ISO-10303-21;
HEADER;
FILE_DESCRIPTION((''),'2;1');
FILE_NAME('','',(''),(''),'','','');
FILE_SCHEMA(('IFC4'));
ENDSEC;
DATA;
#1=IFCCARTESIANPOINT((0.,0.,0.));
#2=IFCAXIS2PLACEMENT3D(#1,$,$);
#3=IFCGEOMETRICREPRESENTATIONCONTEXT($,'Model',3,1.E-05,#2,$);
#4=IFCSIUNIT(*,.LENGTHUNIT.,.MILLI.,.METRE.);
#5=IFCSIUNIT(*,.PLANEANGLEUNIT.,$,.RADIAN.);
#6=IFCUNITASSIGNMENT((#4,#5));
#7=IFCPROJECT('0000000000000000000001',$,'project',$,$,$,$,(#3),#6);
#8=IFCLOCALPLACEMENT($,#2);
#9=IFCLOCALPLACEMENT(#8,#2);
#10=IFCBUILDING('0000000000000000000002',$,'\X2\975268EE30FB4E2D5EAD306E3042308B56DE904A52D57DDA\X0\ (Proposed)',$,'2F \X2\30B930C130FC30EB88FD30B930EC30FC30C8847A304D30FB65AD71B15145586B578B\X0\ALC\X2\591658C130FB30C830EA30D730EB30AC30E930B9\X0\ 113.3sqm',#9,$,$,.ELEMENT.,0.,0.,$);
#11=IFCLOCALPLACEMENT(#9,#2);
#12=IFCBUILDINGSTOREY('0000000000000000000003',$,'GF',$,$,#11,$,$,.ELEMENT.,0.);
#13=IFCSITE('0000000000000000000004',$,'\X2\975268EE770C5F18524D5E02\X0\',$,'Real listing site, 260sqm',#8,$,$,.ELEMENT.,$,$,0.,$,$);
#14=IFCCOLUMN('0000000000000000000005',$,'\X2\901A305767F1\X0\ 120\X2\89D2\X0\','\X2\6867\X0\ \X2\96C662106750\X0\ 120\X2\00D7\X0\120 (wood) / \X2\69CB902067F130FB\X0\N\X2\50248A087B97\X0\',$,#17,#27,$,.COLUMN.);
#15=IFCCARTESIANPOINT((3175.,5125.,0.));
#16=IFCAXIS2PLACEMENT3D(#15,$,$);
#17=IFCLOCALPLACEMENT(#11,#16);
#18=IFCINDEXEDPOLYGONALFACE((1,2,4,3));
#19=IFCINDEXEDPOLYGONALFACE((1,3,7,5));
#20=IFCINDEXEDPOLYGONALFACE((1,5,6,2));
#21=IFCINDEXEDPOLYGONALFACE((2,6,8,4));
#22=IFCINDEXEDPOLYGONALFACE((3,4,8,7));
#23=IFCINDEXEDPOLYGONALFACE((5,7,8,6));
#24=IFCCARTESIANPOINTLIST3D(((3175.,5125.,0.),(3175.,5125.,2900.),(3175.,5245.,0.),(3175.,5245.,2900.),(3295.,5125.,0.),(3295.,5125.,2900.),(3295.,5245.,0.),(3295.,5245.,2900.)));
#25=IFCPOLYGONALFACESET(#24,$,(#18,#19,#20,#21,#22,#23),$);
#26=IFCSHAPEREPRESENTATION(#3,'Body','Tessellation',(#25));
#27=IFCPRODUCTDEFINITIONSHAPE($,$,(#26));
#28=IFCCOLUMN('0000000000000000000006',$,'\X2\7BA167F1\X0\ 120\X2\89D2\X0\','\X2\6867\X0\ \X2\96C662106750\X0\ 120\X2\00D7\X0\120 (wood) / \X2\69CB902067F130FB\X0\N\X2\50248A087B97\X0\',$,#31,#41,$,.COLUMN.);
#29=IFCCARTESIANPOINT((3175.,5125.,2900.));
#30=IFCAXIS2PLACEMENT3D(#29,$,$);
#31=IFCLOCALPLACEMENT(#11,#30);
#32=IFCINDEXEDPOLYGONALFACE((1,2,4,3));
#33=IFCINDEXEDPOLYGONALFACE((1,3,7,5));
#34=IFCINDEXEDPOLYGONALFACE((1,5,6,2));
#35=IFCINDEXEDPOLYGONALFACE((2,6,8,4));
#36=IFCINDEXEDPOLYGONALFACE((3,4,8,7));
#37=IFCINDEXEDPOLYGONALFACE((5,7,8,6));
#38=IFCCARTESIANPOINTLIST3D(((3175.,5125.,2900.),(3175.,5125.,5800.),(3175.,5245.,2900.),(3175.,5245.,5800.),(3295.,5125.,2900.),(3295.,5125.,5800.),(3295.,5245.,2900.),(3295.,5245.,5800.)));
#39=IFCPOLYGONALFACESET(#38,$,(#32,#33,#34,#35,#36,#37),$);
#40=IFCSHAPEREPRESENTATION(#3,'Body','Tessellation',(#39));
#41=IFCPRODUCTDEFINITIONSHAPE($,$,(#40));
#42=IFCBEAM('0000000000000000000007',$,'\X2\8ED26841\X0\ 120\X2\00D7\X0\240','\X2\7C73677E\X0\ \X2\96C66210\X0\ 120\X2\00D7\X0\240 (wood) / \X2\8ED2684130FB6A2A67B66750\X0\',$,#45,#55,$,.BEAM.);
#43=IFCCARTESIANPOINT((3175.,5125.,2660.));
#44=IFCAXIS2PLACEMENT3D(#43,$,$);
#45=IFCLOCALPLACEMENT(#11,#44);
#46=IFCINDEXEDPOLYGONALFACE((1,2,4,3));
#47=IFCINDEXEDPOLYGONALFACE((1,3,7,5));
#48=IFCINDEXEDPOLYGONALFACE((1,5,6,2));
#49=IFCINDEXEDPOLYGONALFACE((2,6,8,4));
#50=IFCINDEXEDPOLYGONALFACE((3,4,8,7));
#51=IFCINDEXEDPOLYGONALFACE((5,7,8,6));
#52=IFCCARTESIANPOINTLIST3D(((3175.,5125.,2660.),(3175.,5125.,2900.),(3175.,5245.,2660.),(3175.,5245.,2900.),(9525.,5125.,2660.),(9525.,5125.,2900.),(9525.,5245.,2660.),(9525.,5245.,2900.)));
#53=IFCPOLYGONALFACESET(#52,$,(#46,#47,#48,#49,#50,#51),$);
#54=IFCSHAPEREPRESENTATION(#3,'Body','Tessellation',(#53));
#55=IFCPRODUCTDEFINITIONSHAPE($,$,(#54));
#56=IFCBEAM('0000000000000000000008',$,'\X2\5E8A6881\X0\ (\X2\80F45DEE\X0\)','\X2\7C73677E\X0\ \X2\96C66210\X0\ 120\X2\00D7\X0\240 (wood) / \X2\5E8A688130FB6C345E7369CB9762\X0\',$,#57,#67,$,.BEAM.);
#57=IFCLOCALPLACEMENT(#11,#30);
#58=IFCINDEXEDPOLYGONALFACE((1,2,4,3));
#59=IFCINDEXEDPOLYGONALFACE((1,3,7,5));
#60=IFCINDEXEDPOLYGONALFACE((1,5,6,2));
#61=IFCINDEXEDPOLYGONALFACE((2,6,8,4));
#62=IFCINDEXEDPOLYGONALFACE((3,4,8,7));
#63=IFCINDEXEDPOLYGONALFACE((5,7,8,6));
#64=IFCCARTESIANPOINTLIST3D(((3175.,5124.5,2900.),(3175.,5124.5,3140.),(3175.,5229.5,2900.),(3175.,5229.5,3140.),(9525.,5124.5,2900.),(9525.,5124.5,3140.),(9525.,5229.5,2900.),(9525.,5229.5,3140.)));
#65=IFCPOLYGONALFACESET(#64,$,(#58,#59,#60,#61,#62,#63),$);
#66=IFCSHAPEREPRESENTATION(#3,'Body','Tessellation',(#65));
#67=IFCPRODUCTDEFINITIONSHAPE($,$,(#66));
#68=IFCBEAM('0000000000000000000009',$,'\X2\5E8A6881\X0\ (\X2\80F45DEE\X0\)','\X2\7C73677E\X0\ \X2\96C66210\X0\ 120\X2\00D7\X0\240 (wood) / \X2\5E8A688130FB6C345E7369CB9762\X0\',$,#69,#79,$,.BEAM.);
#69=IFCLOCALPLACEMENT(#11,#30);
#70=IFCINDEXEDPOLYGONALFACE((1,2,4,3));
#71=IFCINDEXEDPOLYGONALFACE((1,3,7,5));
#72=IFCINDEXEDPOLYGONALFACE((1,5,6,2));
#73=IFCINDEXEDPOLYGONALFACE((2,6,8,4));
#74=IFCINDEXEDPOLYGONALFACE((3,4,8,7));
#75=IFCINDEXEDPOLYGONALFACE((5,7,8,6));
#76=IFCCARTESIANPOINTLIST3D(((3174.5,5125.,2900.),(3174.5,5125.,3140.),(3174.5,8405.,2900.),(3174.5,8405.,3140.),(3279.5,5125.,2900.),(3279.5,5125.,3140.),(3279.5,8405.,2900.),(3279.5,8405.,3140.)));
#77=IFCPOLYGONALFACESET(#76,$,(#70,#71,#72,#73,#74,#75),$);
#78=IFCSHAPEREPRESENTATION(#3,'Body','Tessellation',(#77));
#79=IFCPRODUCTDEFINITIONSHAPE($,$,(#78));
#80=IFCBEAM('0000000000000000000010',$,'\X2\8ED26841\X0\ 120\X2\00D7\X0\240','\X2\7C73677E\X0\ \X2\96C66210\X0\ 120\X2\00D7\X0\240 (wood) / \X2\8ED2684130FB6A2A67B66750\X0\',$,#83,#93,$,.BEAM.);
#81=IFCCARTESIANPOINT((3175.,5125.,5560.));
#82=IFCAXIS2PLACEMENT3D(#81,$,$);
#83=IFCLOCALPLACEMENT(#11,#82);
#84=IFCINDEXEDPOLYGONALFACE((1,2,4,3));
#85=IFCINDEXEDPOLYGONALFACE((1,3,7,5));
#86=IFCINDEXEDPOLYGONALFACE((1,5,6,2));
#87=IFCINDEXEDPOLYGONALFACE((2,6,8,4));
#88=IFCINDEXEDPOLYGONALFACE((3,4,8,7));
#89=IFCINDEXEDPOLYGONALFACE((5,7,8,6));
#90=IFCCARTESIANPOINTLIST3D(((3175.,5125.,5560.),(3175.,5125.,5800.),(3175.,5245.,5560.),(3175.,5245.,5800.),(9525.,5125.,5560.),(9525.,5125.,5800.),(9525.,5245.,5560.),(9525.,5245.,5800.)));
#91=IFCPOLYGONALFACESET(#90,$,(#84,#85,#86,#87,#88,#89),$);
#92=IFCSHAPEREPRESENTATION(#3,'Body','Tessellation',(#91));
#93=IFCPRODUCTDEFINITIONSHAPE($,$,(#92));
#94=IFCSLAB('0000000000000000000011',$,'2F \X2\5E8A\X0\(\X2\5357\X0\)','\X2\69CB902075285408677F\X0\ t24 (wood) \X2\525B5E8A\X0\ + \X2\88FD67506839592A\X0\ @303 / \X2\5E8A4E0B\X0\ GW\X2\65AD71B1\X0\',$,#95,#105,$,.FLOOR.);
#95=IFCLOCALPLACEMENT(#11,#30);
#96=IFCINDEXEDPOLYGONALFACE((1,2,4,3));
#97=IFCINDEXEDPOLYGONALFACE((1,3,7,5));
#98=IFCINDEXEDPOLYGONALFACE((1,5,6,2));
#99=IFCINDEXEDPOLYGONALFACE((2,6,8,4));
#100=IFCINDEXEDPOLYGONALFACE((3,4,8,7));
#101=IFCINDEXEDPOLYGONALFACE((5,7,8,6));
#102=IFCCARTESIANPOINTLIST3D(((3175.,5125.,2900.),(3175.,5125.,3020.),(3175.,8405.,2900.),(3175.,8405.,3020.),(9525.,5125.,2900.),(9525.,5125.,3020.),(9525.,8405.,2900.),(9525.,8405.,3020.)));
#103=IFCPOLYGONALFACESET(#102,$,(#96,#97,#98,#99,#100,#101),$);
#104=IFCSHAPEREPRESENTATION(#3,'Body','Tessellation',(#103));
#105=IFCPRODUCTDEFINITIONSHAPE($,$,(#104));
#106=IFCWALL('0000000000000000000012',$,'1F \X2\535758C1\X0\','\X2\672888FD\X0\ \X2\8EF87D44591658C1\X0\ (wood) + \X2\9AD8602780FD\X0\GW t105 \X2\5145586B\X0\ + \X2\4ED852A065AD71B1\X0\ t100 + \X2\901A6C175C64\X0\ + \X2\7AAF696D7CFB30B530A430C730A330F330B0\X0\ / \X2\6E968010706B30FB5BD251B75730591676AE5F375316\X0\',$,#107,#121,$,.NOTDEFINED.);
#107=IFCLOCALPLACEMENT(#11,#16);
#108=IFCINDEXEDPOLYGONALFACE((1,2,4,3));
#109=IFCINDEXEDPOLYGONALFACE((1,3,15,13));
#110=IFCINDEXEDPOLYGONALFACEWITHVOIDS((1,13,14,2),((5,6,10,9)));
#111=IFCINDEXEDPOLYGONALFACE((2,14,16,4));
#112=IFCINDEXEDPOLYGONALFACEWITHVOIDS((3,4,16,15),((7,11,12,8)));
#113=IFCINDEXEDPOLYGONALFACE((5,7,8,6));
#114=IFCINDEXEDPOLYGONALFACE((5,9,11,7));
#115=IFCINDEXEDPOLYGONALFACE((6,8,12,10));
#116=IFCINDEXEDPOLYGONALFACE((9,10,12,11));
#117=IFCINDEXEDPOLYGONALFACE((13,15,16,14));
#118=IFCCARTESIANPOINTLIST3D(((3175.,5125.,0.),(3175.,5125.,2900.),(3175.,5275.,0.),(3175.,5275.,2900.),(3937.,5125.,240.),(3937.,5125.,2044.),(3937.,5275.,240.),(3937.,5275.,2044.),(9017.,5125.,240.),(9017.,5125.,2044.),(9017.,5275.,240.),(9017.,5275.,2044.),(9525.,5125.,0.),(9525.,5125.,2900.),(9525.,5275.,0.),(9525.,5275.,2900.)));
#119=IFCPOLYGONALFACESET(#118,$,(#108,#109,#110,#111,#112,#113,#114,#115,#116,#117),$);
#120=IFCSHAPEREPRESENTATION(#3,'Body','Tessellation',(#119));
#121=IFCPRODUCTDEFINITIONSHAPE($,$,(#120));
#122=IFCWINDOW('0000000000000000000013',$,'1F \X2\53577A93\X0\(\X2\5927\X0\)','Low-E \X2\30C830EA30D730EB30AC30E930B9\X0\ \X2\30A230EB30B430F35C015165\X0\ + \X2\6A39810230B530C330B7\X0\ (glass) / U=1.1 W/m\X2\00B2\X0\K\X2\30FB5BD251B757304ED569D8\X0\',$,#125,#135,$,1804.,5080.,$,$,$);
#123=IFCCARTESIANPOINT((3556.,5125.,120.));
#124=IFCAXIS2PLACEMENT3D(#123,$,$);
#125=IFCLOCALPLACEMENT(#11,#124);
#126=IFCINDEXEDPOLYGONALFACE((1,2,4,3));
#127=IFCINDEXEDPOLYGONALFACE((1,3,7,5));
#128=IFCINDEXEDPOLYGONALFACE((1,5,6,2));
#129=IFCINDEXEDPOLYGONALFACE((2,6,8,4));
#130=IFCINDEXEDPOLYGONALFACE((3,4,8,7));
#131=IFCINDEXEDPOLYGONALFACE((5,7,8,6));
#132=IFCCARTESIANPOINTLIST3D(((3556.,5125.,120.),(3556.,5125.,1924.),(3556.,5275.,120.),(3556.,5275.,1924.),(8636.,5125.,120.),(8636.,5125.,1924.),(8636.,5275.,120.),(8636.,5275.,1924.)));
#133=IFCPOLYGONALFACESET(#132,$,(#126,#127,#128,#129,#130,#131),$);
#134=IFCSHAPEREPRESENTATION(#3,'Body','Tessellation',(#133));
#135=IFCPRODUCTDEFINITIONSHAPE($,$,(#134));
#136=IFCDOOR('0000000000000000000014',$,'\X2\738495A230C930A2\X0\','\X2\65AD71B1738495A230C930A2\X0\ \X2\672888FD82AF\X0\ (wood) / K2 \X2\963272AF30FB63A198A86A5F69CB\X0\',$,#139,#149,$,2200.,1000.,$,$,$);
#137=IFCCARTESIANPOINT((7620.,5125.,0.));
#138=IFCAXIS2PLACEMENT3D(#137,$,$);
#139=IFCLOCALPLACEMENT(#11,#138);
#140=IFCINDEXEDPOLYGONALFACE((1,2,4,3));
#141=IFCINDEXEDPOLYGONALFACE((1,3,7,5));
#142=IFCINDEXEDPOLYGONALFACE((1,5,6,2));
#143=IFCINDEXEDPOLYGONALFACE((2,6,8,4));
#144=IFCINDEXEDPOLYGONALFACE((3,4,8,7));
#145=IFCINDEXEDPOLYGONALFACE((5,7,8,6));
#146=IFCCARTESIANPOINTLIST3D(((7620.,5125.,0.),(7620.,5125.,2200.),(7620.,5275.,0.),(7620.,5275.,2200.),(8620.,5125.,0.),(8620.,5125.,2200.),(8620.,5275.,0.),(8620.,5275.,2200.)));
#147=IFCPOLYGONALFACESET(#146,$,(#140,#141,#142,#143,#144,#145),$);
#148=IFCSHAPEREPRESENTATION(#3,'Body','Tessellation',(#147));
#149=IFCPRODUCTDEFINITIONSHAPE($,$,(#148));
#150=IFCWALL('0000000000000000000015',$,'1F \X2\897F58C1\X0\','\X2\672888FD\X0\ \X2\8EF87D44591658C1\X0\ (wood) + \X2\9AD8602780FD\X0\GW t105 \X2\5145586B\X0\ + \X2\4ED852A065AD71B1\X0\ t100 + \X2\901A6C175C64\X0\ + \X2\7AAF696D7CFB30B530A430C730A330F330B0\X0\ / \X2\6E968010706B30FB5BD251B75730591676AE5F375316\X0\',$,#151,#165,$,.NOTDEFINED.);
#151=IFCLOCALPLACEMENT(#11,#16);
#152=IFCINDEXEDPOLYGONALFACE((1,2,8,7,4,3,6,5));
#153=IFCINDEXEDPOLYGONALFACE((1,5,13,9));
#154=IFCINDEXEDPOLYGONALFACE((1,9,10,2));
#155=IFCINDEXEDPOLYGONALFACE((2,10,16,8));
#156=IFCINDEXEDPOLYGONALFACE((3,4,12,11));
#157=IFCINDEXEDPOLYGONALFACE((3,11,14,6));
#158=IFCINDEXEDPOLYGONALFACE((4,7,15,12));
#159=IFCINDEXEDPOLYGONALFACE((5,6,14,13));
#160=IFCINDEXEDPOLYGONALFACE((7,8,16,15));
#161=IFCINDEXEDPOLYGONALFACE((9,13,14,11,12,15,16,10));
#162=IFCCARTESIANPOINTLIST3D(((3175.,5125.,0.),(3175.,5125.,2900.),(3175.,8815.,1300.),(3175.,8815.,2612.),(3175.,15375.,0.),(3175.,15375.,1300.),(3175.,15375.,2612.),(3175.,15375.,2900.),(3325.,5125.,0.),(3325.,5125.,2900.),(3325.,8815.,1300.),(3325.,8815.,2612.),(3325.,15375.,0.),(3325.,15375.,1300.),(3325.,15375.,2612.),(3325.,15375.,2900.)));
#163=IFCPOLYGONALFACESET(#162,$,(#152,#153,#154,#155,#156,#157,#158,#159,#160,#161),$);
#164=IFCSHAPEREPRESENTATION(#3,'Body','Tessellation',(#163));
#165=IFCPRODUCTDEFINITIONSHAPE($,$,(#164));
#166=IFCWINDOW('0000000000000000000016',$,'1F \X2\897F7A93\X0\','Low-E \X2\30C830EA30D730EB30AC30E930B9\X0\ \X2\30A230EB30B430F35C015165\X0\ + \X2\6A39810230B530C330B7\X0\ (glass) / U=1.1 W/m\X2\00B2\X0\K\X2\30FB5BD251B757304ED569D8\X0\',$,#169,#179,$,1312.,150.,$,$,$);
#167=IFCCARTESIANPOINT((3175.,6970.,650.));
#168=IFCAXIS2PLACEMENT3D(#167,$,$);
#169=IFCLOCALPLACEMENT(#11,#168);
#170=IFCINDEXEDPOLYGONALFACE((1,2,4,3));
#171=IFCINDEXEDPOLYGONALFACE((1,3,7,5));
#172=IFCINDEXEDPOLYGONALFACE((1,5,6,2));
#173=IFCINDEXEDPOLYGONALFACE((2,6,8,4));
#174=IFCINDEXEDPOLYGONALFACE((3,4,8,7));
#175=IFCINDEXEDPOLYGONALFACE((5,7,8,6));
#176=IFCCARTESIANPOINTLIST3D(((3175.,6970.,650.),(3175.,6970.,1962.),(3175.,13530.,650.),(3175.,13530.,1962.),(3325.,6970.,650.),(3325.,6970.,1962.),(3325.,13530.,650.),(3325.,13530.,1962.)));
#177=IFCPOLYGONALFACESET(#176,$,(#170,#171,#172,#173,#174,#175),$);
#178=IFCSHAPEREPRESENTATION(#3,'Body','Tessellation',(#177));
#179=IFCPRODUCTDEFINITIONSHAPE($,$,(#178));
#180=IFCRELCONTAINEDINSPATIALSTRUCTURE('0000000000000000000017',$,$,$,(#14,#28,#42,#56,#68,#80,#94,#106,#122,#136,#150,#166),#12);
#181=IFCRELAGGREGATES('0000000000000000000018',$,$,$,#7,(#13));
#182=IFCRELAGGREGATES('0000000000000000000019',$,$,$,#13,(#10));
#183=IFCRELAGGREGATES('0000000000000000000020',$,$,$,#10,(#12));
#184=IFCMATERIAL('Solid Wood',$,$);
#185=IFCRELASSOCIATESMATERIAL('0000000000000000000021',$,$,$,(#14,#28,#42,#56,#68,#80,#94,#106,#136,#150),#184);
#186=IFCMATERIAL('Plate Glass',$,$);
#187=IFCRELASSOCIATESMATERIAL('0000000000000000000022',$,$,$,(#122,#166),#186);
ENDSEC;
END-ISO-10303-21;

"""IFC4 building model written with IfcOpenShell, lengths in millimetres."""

from ifc_helpers import new_model, si_unit, frame, frame_2d, origin, place, context, project, spatial, rectangle, extrude, material, element, fill, save


model = new_model("IFC4")

# Units and contexts
model_context = context("Model", 3, precision=1e-05, world=origin())
ifc_project = project(units=[si_unit("LENGTHUNIT", "METRE", prefix="MILLI"), si_unit("PLANEANGLEUNIT", "RADIAN")], contexts=[model_context])

# Site, building, storey
site_placement = place(None, origin())
site = spatial("IfcSite", under=ifc_project, at=site_placement, Name="青森県弘前市", ObjectType="Real listing site, 260sqm", CompositionType="ELEMENT", RefElevation=0.0)
building_placement = place(site_placement, origin())
building = spatial("IfcBuilding", under=site, at=building_placement, Name="青森・中庭のある回遊動線 (Proposed)", ObjectType="2F スチール製スレート葺き・断熱充填型ALC外壁・トリプルガラス 113.3sqm", CompositionType="ELEMENT", ElevationOfRefHeight=0.0, ElevationOfTerrain=0.0)
storey_placement = place(building_placement, origin())
storey = spatial("IfcBuildingStorey", under=building, at=storey_placement, Name="GF", CompositionType="ELEMENT", Elevation=0.0)

# Columns
ifc_material_1 = material(Name="Solid Wood")
column_1_placement = place(storey_placement, frame((3175.0, 5125.0, 0.0)))
element("IfcColumn", 1, at=column_1_placement, inside=storey, material=ifc_material_1, Name="通し柱 120角", Description="桧 集成材 120×120 (wood) / 構造柱・N値計算", PredefinedType="COLUMN", context=model_context, shape_type="SweptSolid", body=[
    extrude(rectangle(XDim=120.0, YDim=120.0, at=frame_2d((60.0, 60.0))), frame((3175.0, 5125.0, 0.0)), (0.0, 0.0, 1.0), 2900.0),
])
column_2_placement = place(storey_placement, frame((3175.0, 5125.0, 2900.0)))
element("IfcColumn", 2, at=column_2_placement, inside=storey, material=ifc_material_1, Name="管柱 120角", Description="桧 集成材 120×120 (wood) / 構造柱・N値計算", PredefinedType="COLUMN", context=model_context, shape_type="SweptSolid", body=[
    extrude(rectangle(XDim=120.0, YDim=120.0, at=frame_2d((60.0, 60.0))), frame((3175.0, 5125.0, 2900.0)), (0.0, 0.0, 1.0), 2900.0),
])

# Beams
beam_1_placement = place(storey_placement, frame((3175.0, 5125.0, 2660.0)))
element("IfcBeam", 3, at=beam_1_placement, inside=storey, material=ifc_material_1, Name="軒桁 120×240", Description="米松 集成 120×240 (wood) / 軒桁・横架材", PredefinedType="BEAM", context=model_context, shape_type="SweptSolid", body=[
    extrude(rectangle(XDim=6350.0, YDim=120.0, at=frame_2d((3175.0, 60.0))), frame((3175.0, 5125.0, 2660.0)), (0.0, 0.0, 1.0), 240.0),
])
beam_2_placement = place(storey_placement, frame((3175.0, 5125.0, 2900.0)))
element("IfcBeam", 4, at=beam_2_placement, inside=storey, material=ifc_material_1, Name="床梁 (胴差)", Description="米松 集成 120×240 (wood) / 床梁・水平構面", PredefinedType="BEAM", context=model_context, shape_type="SweptSolid", body=[
    extrude(rectangle(XDim=6350.0, YDim=105.0, at=frame_2d((3175.0, 52.0))), frame((3175.0, 5125.0, 2900.0)), (0.0, 0.0, 1.0), 240.0),
])
beam_3_placement = place(storey_placement, frame((3175.0, 5125.0, 2900.0)))
element("IfcBeam", 5, at=beam_3_placement, inside=storey, material=ifc_material_1, Name="床梁 (胴差)", Description="米松 集成 120×240 (wood) / 床梁・水平構面", PredefinedType="BEAM", context=model_context, shape_type="SweptSolid", body=[
    extrude(rectangle(XDim=105.0, YDim=3280.0, at=frame_2d((52.0, 1640.0))), frame((3175.0, 5125.0, 2900.0)), (0.0, 0.0, 1.0), 240.0),
])
beam_4_placement = place(storey_placement, frame((3175.0, 5125.0, 5560.0)))
element("IfcBeam", 6, at=beam_4_placement, inside=storey, material=ifc_material_1, Name="軒桁 120×240", Description="米松 集成 120×240 (wood) / 軒桁・横架材", PredefinedType="BEAM", context=model_context, shape_type="SweptSolid", body=[
    extrude(rectangle(XDim=6350.0, YDim=120.0, at=frame_2d((3175.0, 60.0))), frame((3175.0, 5125.0, 5560.0)), (0.0, 0.0, 1.0), 240.0),
])

# Slab
slab_1_placement = place(storey_placement, frame((3175.0, 5125.0, 2900.0)))
element("IfcSlab", 7, at=slab_1_placement, inside=storey, material=ifc_material_1, Name="2F 床(南)", Description="構造用合板 t24 (wood) 剛床 + 製材根太 @303 / 床下 GW断熱", PredefinedType="FLOOR", context=model_context, shape_type="SweptSolid", body=[
    extrude(rectangle(XDim=6350.0, YDim=3280.0, at=frame_2d((3175.0, 1640.0))), frame((3175.0, 5125.0, 2900.0)), (0.0, 0.0, 1.0), 120.0),
])

# Wall, openings, window, door
wall_1_placement = place(storey_placement, frame((3175.0, 5125.0, 0.0)))
wall_1 = element("IfcWall", 8, at=wall_1_placement, inside=storey, material=ifc_material_1, Name="1F 南壁", Description="木製 軸組外壁 (wood) + 高性能GW t105 充填 + 付加断熱 t100 + 通気層 + 窯業系サイディング / 準耐火・寒冷地外皮強化", PredefinedType="NOTDEFINED", context=model_context, shape_type="SweptSolid", body=[
    extrude(rectangle(XDim=6350.0, YDim=150.0, at=frame_2d((3175.0, 75.0))), frame((3175.0, 5125.0, 0.0)), (0.0, 0.0, 1.0), 2900.0),
])
opening_1_placement = place(storey_placement, frame((3556.0, 5125.0, 120.0)))
opening_1 = element("IfcOpeningElement", 9, at=opening_1_placement, cuts=wall_1, PredefinedType="NOTDEFINED", context=model_context, shape_type="SweptSolid", body=[
    extrude(rectangle(XDim=5080.0, YDim=150.0, at=frame_2d((2540.0, 75.0))), frame((3556.0, 5125.0, 120.0)), (0.0, 0.0, 1.0), 1804.0),
])
opening_2_placement = place(storey_placement, frame((7620.0, 5125.0, 0.0)))
opening_2 = element("IfcOpeningElement", 10, at=opening_2_placement, cuts=wall_1, PredefinedType="NOTDEFINED", context=model_context, shape_type="SweptSolid", body=[
    extrude(rectangle(XDim=1000.0, YDim=150.0, at=frame_2d((500.0, 75.0))), frame((7620.0, 5125.0, 0.0)), (0.0, 0.0, 1.0), 2200.0),
])
ifc_material_2 = material(Name="Plate Glass")
window_1_placement = place(storey_placement, frame((3556.0, 5125.0, 120.0)))
window_1 = element("IfcWindow", 11, at=window_1_placement, inside=storey, material=ifc_material_2, Name="1F 南窓(大)", Description="Low-E トリプルガラス アルゴン封入 + 樹脂サッシ (glass) / U=1.1 W/m²K・寒冷地仕様", OverallHeight=1804.0, OverallWidth=5080.0, context=model_context, shape_type="SweptSolid", body=[
    extrude(rectangle(XDim=5080.0, YDim=150.0, at=frame_2d((2540.0, 75.0))), frame((3556.0, 5125.0, 120.0)), (0.0, 0.0, 1.0), 1804.0),
])
fill(opening_1, window_1)
door_placement = place(storey_placement, frame((7620.0, 5125.0, 0.0)))
door = element("IfcDoor", 12, at=door_placement, inside=storey, material=ifc_material_1, Name="玄関ドア", Description="断熱玄関ドア 木製芯 (wood) / K2 防犯・採風機構", OverallHeight=2200.0, OverallWidth=1000.0, context=model_context, shape_type="SweptSolid", body=[
    extrude(rectangle(XDim=1000.0, YDim=150.0, at=frame_2d((500.0, 75.0))), frame((7620.0, 5125.0, 0.0)), (0.0, 0.0, 1.0), 2200.0),
])
fill(opening_2, door)

# Wall, opening, window
wall_2_placement = place(storey_placement, frame((3175.0, 5125.0, 0.0)))
wall_2 = element("IfcWall", 13, at=wall_2_placement, inside=storey, material=ifc_material_1, Name="1F 西壁", Description="木製 軸組外壁 (wood) + 高性能GW t105 充填 + 付加断熱 t100 + 通気層 + 窯業系サイディング / 準耐火・寒冷地外皮強化", PredefinedType="NOTDEFINED", context=model_context, shape_type="SweptSolid", body=[
    extrude(rectangle(XDim=150.0, YDim=10250.0, at=frame_2d((75.0, 5125.0))), frame((3175.0, 5125.0, 0.0)), (0.0, 0.0, 1.0), 2900.0),
])
opening_3_placement = place(storey_placement, frame((3175.0, 6970.0, 650.0)))
opening_3 = element("IfcOpeningElement", 14, at=opening_3_placement, cuts=wall_2, PredefinedType="NOTDEFINED", context=model_context, shape_type="SweptSolid", body=[
    extrude(rectangle(XDim=150.0, YDim=6560.0, at=frame_2d((75.0, 3280.0))), frame((3175.0, 6970.0, 650.0)), (0.0, 0.0, 1.0), 1312.0),
])
window_2_placement = place(storey_placement, frame((3175.0, 6970.0, 650.0)))
window_2 = element("IfcWindow", 15, at=window_2_placement, inside=storey, material=ifc_material_2, Name="1F 西窓", Description="Low-E トリプルガラス アルゴン封入 + 樹脂サッシ (glass) / U=1.1 W/m²K・寒冷地仕様", OverallHeight=1312.0, OverallWidth=150.0, context=model_context, shape_type="SweptSolid", body=[
    extrude(rectangle(XDim=150.0, YDim=6560.0, at=frame_2d((75.0, 3280.0))), frame((3175.0, 6970.0, 650.0)), (0.0, 0.0, 1.0), 1312.0),
])
fill(opening_3, window_2)

save(model, "model.ifc")
